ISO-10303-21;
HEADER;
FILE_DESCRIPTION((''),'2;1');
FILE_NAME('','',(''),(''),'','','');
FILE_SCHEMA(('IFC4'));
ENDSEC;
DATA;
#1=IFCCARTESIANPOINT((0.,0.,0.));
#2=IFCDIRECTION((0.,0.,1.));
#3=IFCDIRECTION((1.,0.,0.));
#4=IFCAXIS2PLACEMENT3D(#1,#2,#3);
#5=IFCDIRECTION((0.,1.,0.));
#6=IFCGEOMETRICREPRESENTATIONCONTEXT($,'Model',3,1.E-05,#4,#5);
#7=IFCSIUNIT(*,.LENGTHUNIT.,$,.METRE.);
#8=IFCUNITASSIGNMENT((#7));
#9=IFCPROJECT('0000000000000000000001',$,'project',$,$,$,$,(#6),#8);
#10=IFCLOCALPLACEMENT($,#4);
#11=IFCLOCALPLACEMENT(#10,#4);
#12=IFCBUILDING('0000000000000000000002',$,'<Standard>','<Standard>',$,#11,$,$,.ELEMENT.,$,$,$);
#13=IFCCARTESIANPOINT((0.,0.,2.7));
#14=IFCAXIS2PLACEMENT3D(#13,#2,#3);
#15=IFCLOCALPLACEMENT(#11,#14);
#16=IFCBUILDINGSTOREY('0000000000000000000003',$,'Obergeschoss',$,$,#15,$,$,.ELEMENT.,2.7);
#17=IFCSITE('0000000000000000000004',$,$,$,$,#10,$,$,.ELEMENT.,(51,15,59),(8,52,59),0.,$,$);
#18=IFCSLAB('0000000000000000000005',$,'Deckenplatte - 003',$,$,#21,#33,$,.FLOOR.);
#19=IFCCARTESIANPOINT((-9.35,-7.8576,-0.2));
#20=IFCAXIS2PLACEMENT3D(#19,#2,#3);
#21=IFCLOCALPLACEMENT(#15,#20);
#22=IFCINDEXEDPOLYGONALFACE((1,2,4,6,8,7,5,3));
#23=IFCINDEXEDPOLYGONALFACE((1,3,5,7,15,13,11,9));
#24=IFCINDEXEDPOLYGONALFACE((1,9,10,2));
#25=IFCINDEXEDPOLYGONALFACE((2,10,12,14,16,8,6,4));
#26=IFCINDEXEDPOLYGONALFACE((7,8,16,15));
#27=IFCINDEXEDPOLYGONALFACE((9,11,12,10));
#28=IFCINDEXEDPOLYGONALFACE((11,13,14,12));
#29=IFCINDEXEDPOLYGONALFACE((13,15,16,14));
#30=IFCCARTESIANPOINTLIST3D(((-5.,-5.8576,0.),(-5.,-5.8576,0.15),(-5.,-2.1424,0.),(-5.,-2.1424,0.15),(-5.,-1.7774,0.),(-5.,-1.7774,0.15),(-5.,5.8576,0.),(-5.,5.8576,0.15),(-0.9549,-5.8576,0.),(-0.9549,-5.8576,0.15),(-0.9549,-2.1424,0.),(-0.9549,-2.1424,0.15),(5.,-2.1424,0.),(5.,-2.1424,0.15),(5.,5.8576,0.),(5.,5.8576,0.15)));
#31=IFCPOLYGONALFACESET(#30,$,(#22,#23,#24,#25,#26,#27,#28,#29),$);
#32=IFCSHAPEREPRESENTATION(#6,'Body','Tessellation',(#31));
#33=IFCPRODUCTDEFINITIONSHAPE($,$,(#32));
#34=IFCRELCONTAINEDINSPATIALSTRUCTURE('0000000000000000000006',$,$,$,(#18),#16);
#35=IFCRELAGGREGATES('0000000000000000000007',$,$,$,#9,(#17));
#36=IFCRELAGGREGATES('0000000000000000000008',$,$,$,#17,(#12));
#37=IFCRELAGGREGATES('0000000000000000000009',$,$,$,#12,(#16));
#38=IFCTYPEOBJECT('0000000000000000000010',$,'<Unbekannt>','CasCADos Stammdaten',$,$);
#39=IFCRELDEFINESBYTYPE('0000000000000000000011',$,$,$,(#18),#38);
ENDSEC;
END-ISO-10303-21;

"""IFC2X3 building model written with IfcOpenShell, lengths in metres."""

from ifc_helpers import new_model, si_unit, direction, frame, origin_with_axes, place, context, project, spatial, polyline, outline, extrude, type_object, element, save


model = new_model("IFC2X3")

# Units and contexts
model_context = context("Model", 3, precision=1e-05, world=origin_with_axes(), true_north=direction((0.0, 1.0, 0.0)))
ifc_project = project(units=[si_unit("LENGTHUNIT", "METRE")], contexts=[model_context])

# Site, building, storey
site_placement = place(None, origin_with_axes())
site = spatial("IfcSite", under=ifc_project, at=site_placement, CompositionType="ELEMENT", RefLatitude=(51, 15, 59), RefLongitude=(8, 52, 59), RefElevation=0.0)
building_placement = place(site_placement, origin_with_axes())
building = spatial("IfcBuilding", under=site, at=building_placement, Name="<Standard>", Description="<Standard>", CompositionType="ELEMENT")
storey_placement = place(building_placement, frame((0.0, 0.0, 2.7), z_axis=(0.0, 0.0, 1.0), x_axis=(1.0, 0.0, 0.0)))
storey = spatial("IfcBuildingStorey", under=building, at=storey_placement, Name="Obergeschoss", CompositionType="ELEMENT", Elevation=2.7)

# Slab
ifc_type_object_1 = type_object("IfcTypeObject", Name="<Unbekannt>", Description="CasCADos Stammdaten")
slab_placement = place(storey_placement, frame((-9.35, -7.8576, -0.2), z_axis=(0.0, 0.0, 1.0), x_axis=(1.0, 0.0, 0.0)))
element("IfcSlab", 1, at=slab_placement, inside=storey, type_object=ifc_type_object_1, Name="Deckenplatte - 003", PredefinedType="FLOOR", context=model_context, shape_type="SweptSolid", body=[
    extrude(outline(polyline([(-5.0, -5.8576), (-0.9549, -5.8576), (-0.9549, -2.1424), (5.0, -2.1424), (5.0, 5.8576), (-5.0, 5.8576), (-5.0, -1.7774), (-5.0, -2.1424), (-5.0, -5.8576)])), origin_with_axes(), (0.0, 0.0, 1.0), 0.15),
])

save(model, "model.ifc")
